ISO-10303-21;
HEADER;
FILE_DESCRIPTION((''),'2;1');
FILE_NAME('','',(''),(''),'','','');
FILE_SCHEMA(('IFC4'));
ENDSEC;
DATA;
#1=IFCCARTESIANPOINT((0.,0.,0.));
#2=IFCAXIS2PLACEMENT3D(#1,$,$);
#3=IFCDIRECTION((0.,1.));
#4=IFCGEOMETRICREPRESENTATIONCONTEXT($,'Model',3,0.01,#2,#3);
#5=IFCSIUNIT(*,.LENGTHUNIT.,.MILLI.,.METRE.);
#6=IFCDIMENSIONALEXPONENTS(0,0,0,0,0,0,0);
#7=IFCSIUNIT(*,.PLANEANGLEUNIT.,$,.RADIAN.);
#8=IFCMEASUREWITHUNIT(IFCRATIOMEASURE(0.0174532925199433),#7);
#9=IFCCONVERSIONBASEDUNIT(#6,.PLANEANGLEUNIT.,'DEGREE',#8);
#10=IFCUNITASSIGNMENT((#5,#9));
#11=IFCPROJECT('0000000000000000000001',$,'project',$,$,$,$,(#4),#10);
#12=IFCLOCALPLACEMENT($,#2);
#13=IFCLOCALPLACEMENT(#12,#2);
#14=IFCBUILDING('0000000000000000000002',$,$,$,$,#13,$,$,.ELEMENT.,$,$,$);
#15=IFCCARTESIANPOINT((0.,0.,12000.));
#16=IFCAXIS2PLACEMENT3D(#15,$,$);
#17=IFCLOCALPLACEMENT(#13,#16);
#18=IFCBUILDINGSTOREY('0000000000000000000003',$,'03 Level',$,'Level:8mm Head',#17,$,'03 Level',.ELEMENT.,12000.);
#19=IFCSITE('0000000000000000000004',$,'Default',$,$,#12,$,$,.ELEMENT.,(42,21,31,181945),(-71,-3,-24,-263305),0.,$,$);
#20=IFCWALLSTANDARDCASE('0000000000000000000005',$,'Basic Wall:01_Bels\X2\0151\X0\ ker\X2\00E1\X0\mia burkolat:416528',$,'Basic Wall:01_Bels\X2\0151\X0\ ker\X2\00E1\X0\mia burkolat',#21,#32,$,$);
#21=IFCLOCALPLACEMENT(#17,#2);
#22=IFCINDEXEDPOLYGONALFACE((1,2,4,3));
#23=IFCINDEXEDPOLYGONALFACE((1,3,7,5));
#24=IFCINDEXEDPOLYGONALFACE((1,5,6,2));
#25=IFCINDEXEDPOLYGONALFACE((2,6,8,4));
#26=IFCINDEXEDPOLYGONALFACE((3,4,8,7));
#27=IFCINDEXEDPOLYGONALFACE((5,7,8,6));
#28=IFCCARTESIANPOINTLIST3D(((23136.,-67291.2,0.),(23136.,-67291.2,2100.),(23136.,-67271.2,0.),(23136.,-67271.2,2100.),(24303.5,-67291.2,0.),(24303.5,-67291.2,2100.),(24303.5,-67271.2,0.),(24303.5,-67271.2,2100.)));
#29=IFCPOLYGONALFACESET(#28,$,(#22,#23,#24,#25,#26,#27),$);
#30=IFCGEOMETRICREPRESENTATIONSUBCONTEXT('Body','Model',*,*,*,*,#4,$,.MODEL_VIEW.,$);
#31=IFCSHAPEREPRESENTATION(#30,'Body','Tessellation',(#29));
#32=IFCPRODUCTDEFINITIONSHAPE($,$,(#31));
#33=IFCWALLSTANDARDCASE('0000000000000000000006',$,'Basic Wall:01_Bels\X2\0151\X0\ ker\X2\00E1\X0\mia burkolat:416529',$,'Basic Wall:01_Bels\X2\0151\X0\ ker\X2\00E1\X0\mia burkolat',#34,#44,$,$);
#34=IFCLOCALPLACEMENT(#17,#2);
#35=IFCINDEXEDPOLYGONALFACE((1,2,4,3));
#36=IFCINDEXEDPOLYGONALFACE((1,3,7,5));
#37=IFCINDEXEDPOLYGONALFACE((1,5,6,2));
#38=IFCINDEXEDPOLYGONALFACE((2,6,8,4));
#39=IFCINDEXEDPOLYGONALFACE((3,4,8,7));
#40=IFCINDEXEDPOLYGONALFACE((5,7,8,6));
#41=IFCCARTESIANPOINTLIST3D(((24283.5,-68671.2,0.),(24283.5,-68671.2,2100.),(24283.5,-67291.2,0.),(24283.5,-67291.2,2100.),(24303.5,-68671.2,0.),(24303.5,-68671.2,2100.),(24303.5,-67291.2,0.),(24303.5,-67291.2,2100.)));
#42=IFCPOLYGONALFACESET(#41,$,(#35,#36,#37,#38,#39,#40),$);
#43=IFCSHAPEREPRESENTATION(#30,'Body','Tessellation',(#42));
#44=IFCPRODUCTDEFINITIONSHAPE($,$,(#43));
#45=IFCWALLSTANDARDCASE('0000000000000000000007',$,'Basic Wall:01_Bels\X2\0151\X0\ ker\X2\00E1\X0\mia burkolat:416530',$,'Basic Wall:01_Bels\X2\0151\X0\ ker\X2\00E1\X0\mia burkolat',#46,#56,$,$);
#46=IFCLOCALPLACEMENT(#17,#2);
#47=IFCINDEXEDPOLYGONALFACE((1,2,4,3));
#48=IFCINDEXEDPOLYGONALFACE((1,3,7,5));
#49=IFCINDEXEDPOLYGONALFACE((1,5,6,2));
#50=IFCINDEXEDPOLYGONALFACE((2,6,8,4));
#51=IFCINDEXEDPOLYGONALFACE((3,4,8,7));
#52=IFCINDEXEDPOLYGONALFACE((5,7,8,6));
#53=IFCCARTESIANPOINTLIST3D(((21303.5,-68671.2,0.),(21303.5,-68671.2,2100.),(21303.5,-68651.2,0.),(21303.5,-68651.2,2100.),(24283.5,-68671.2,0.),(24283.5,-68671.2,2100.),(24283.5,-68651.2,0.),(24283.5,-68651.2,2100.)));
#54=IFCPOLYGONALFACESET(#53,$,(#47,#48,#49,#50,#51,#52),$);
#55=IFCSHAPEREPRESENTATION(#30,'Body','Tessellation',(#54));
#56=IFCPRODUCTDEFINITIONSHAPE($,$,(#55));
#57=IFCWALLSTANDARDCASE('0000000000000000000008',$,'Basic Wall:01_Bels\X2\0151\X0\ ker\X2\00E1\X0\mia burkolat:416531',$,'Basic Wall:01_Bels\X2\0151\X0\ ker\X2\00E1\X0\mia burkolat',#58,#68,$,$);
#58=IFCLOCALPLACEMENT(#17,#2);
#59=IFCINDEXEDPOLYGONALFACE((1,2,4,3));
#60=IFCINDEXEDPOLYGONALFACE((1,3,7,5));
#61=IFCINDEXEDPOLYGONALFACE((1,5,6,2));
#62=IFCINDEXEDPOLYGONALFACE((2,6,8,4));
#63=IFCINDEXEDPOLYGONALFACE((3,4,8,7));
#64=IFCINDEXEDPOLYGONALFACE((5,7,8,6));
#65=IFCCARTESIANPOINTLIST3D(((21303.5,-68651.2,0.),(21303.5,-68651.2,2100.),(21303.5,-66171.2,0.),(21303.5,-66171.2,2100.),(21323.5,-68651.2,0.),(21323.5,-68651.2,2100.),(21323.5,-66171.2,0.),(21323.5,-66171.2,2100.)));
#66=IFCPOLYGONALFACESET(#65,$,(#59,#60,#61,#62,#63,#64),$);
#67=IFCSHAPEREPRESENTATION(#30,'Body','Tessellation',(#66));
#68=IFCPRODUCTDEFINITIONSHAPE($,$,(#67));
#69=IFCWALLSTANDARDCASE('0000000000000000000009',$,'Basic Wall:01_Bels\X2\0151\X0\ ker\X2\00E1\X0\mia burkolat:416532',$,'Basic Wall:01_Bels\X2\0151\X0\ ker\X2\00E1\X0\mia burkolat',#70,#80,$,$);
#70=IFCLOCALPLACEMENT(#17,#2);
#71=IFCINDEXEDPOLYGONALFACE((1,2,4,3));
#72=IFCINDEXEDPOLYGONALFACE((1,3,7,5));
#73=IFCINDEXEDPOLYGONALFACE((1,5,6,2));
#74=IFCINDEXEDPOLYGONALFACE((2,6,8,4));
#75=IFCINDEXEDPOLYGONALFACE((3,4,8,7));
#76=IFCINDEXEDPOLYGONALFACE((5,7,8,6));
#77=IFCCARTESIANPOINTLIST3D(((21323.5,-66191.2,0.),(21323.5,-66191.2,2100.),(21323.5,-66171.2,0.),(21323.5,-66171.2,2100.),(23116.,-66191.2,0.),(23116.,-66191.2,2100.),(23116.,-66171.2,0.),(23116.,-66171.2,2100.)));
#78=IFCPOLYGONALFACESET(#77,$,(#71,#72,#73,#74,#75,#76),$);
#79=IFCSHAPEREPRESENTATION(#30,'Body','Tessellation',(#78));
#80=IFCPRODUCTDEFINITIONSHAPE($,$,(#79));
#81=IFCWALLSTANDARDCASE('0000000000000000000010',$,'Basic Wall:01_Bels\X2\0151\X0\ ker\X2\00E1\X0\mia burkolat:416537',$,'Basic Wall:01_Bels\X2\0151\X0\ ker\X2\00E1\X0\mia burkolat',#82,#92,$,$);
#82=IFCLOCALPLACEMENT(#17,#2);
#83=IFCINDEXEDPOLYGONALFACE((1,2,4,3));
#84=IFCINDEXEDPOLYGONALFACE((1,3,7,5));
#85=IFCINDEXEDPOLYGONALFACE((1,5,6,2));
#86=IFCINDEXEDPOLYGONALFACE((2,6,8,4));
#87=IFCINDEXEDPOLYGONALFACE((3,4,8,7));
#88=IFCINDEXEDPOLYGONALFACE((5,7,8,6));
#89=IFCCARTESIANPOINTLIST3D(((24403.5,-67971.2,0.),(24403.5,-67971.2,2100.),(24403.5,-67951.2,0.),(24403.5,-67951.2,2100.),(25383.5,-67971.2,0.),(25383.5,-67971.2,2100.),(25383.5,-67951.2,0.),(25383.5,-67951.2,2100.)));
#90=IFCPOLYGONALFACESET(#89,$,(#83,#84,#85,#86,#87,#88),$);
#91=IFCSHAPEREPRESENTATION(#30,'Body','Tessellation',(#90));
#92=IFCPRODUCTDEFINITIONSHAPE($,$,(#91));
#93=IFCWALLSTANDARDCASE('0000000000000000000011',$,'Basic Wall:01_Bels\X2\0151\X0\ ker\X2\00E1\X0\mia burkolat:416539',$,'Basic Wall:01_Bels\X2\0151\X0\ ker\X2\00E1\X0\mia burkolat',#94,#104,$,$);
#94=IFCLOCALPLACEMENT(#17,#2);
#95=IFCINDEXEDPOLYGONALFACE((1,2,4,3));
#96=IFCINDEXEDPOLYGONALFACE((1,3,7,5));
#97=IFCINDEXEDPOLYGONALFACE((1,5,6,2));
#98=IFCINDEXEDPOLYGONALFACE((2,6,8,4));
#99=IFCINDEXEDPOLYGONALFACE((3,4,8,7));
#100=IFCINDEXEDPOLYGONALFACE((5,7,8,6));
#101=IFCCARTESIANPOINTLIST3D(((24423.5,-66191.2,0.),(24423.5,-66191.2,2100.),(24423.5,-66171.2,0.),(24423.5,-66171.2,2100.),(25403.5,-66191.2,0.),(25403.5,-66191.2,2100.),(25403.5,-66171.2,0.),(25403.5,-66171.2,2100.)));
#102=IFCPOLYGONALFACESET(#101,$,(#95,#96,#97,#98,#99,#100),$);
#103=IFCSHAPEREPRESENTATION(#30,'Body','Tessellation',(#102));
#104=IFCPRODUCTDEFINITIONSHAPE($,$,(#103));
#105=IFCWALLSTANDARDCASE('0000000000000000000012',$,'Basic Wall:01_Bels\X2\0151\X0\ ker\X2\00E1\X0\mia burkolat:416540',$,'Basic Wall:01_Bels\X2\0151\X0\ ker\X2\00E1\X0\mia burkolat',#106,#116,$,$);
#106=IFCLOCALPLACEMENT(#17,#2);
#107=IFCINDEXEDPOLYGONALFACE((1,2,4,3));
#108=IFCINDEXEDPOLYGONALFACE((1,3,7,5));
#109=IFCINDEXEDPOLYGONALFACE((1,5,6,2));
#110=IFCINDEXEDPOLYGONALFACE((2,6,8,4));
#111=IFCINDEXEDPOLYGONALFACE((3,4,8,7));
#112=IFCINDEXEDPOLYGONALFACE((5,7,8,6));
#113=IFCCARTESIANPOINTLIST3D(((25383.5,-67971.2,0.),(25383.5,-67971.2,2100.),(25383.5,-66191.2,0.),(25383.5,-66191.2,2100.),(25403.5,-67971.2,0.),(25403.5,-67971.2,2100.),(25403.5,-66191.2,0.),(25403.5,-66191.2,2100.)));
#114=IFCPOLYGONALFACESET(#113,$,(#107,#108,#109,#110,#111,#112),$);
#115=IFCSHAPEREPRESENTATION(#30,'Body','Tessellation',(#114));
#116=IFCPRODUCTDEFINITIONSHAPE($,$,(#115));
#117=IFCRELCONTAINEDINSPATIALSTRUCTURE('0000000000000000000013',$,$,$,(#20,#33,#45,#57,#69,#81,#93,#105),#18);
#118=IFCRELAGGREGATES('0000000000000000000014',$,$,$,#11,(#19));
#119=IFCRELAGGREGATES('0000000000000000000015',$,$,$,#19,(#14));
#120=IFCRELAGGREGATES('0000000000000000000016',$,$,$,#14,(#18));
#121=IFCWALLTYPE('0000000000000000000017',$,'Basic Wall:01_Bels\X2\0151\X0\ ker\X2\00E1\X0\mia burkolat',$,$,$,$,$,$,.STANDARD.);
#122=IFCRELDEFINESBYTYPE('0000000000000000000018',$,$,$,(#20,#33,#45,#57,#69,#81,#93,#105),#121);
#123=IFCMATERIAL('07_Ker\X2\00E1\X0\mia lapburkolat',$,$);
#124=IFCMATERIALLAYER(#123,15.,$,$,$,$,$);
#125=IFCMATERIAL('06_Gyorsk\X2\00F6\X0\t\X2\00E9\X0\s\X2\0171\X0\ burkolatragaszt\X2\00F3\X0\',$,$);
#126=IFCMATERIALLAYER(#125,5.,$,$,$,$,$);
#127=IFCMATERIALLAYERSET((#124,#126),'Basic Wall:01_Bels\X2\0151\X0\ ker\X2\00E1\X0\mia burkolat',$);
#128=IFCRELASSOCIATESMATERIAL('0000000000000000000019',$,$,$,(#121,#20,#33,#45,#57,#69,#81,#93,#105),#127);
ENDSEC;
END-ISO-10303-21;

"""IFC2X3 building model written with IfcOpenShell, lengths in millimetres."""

from ifc_helpers import new_model, entity, si_unit, converted_unit, direction, frame, frame_2d, origin, place, context, subcontext, project, spatial, rectangle, extrude, material, layer, layer_set, layer_usage, type_object, element, save


model = new_model("IFC2X3")

# Units and contexts
model_context = context("Model", 3, precision=0.01, world=origin(), true_north=direction((0.0, 1.0)))
body_context = subcontext(model_context, "Body", "Model", "MODEL_VIEW")
ifc_project = project(units=[si_unit("LENGTHUNIT", "METRE", prefix="MILLI"), converted_unit("PLANEANGLEUNIT", "DEGREE", entity("IfcRatioMeasure", 0.0174532925199433), si_unit("PLANEANGLEUNIT", "RADIAN"), dimensions=[0, 0, 0, 0, 0, 0, 0])], contexts=[model_context])

# Site, building, storey
site_placement = place(None, origin())
site = spatial("IfcSite", under=ifc_project, at=site_placement, Name="Default", CompositionType="ELEMENT", RefLatitude=(42, 21, 31, 181945), RefLongitude=(-71, -3, -24, -263305), RefElevation=0.0)
building_placement = place(site_placement, origin())
building = spatial("IfcBuilding", under=site, at=building_placement, CompositionType="ELEMENT")
storey_placement = place(building_placement, frame((0.0, 0.0, 12000.0)))
storey = spatial("IfcBuildingStorey", under=building, at=storey_placement, Name="03 Level", ObjectType="Level:8mm Head", LongName="03 Level", CompositionType="ELEMENT", Elevation=12000.0)

# Shared definitions
ifc_material_1 = material(Name="07_Kerámia lapburkolat")
ifc_layer_1 = layer(ifc_material_1, 15.0)
ifc_material_2 = material(Name="06_Gyorskötésű burkolatragasztó")
ifc_layer_2 = layer(ifc_material_2, 5.0)
ifc_layer_set_1 = layer_set([ifc_layer_1, ifc_layer_2], Name="Basic Wall:01_Belső kerámia burkolat")
wall_type_1 = type_object("IfcWallType", Name="Basic Wall:01_Belső kerámia burkolat", PredefinedType="STANDARD", material=ifc_layer_set_1)

# Walls
ifc_layer_usage_1 = layer_usage(ifc_layer_set_1, "AXIS2", "POSITIVE", -10.0)
wall_1_placement = place(storey_placement, frame((23136.0, -67281.2, 0.0)))
element("IfcWallStandardCase", 1, at=wall_1_placement, inside=storey, type_object=wall_type_1, material=ifc_layer_usage_1, Name="Basic Wall:01_Belső kerámia burkolat:416528", ObjectType="Basic Wall:01_Belső kerámia burkolat", context=body_context, shape_type="SweptSolid", body=[
    extrude(rectangle(XDim=1167.5, YDim=20.0, at=frame_2d((583.7, 0.0), x_axis=(-1.0, 0.0))), origin(), (0.0, 0.0, 1.0), 2100.0),
])
ifc_layer_usage_2 = layer_usage(ifc_layer_set_1, "AXIS2", "POSITIVE", -10.0)
wall_2_placement = place(storey_placement, frame((24293.5, -67291.2, 0.0), z_axis=(0.0, 0.0, 1.0), x_axis=(0.0, -1.0, 0.0)))
element("IfcWallStandardCase", 2, at=wall_2_placement, inside=storey, type_object=wall_type_1, material=ifc_layer_usage_2, Name="Basic Wall:01_Belső kerámia burkolat:416529", ObjectType="Basic Wall:01_Belső kerámia burkolat", context=body_context, shape_type="SweptSolid", body=[
    extrude(rectangle(XDim=1380.0, YDim=20.0, at=frame_2d((690.0, 0.0), x_axis=(-1.0, 0.0))), origin(), (0.0, 0.0, 1.0), 2100.0),
])
ifc_layer_usage_3 = layer_usage(ifc_layer_set_1, "AXIS2", "POSITIVE", -10.0)
wall_3_placement = place(storey_placement, frame((24283.5, -68661.2, 0.0), z_axis=(0.0, 0.0, 1.0), x_axis=(-1.0, 0.0, 0.0)))
element("IfcWallStandardCase", 3, at=wall_3_placement, inside=storey, type_object=wall_type_1, material=ifc_layer_usage_3, Name="Basic Wall:01_Belső kerámia burkolat:416530", ObjectType="Basic Wall:01_Belső kerámia burkolat", context=body_context, shape_type="SweptSolid", body=[
    extrude(rectangle(XDim=2980.0, YDim=20.0, at=frame_2d((1490.0, 0.0), x_axis=(-1.0, 0.0))), origin(), (0.0, 0.0, 1.0), 2100.0),
])
ifc_layer_usage_4 = layer_usage(ifc_layer_set_1, "AXIS2", "POSITIVE", -10.0)
wall_4_placement = place(storey_placement, frame((21313.5, -68651.2, 0.0), z_axis=(0.0, 0.0, 1.0), x_axis=(0.0, 1.0, 0.0)))
element("IfcWallStandardCase", 4, at=wall_4_placement, inside=storey, type_object=wall_type_1, material=ifc_layer_usage_4, Name="Basic Wall:01_Belső kerámia burkolat:416531", ObjectType="Basic Wall:01_Belső kerámia burkolat", context=body_context, shape_type="SweptSolid", body=[
    extrude(rectangle(XDim=2480.0, YDim=20.0, at=frame_2d((1240.0, 0.0), x_axis=(-1.0, 0.0))), origin(), (0.0, 0.0, 1.0), 2100.0),
])
ifc_layer_usage_5 = layer_usage(ifc_layer_set_1, "AXIS2", "POSITIVE", -10.0)
wall_5_placement = place(storey_placement, frame((21323.5, -66181.2, 0.0)))
element("IfcWallStandardCase", 5, at=wall_5_placement, inside=storey, type_object=wall_type_1, material=ifc_layer_usage_5, Name="Basic Wall:01_Belső kerámia burkolat:416532", ObjectType="Basic Wall:01_Belső kerámia burkolat", context=body_context, shape_type="SweptSolid", body=[
    extrude(rectangle(XDim=1792.5, YDim=20.0, at=frame_2d((896.3, 0.0), x_axis=(-1.0, 0.0))), origin(), (0.0, 0.0, 1.0), 2100.0),
])
ifc_layer_usage_6 = layer_usage(ifc_layer_set_1, "AXIS2", "NEGATIVE", 10.0)
wall_6_placement = place(storey_placement, frame((24403.5, -67961.2, 0.0)))
element("IfcWallStandardCase", 6, at=wall_6_placement, inside=storey, type_object=wall_type_1, material=ifc_layer_usage_6, Name="Basic Wall:01_Belső kerámia burkolat:416537", ObjectType="Basic Wall:01_Belső kerámia burkolat", context=body_context, shape_type="SweptSolid", body=[
    extrude(rectangle(XDim=980.0, YDim=20.0, at=frame_2d((490.0, 0.0), x_axis=(-1.0, 0.0))), origin(), (0.0, 0.0, 1.0), 2100.0),
])

# Walls
ifc_layer_usage_7 = layer_usage(ifc_layer_set_1, "AXIS2", "NEGATIVE", 10.0)
wall_7_placement = place(storey_placement, frame((25403.5, -66181.2, 0.0), z_axis=(0.0, 0.0, 1.0), x_axis=(-1.0, 0.0, 0.0)))
element("IfcWallStandardCase", 7, at=wall_7_placement, inside=storey, type_object=wall_type_1, material=ifc_layer_usage_7, Name="Basic Wall:01_Belső kerámia burkolat:416539", ObjectType="Basic Wall:01_Belső kerámia burkolat", context=body_context, shape_type="SweptSolid", body=[
    extrude(rectangle(XDim=980.0, YDim=20.0, at=frame_2d((490.0, 0.0), x_axis=(-1.0, 0.0))), origin(), (0.0, 0.0, 1.0), 2100.0),
])
ifc_layer_usage_8 = layer_usage(ifc_layer_set_1, "AXIS2", "NEGATIVE", 10.0)
wall_8_placement = place(storey_placement, frame((25393.5, -67971.2, 0.0), z_axis=(0.0, 0.0, 1.0), x_axis=(0.0, 1.0, 0.0)))
element("IfcWallStandardCase", 8, at=wall_8_placement, inside=storey, type_object=wall_type_1, material=ifc_layer_usage_8, Name="Basic Wall:01_Belső kerámia burkolat:416540", ObjectType="Basic Wall:01_Belső kerámia burkolat", context=body_context, shape_type="SweptSolid", body=[
    extrude(rectangle(XDim=1780.0, YDim=20.0, at=frame_2d((890.0, 0.0), x_axis=(-1.0, 0.0))), origin(), (0.0, 0.0, 1.0), 2100.0),
])

save(model, "model.ifc")
